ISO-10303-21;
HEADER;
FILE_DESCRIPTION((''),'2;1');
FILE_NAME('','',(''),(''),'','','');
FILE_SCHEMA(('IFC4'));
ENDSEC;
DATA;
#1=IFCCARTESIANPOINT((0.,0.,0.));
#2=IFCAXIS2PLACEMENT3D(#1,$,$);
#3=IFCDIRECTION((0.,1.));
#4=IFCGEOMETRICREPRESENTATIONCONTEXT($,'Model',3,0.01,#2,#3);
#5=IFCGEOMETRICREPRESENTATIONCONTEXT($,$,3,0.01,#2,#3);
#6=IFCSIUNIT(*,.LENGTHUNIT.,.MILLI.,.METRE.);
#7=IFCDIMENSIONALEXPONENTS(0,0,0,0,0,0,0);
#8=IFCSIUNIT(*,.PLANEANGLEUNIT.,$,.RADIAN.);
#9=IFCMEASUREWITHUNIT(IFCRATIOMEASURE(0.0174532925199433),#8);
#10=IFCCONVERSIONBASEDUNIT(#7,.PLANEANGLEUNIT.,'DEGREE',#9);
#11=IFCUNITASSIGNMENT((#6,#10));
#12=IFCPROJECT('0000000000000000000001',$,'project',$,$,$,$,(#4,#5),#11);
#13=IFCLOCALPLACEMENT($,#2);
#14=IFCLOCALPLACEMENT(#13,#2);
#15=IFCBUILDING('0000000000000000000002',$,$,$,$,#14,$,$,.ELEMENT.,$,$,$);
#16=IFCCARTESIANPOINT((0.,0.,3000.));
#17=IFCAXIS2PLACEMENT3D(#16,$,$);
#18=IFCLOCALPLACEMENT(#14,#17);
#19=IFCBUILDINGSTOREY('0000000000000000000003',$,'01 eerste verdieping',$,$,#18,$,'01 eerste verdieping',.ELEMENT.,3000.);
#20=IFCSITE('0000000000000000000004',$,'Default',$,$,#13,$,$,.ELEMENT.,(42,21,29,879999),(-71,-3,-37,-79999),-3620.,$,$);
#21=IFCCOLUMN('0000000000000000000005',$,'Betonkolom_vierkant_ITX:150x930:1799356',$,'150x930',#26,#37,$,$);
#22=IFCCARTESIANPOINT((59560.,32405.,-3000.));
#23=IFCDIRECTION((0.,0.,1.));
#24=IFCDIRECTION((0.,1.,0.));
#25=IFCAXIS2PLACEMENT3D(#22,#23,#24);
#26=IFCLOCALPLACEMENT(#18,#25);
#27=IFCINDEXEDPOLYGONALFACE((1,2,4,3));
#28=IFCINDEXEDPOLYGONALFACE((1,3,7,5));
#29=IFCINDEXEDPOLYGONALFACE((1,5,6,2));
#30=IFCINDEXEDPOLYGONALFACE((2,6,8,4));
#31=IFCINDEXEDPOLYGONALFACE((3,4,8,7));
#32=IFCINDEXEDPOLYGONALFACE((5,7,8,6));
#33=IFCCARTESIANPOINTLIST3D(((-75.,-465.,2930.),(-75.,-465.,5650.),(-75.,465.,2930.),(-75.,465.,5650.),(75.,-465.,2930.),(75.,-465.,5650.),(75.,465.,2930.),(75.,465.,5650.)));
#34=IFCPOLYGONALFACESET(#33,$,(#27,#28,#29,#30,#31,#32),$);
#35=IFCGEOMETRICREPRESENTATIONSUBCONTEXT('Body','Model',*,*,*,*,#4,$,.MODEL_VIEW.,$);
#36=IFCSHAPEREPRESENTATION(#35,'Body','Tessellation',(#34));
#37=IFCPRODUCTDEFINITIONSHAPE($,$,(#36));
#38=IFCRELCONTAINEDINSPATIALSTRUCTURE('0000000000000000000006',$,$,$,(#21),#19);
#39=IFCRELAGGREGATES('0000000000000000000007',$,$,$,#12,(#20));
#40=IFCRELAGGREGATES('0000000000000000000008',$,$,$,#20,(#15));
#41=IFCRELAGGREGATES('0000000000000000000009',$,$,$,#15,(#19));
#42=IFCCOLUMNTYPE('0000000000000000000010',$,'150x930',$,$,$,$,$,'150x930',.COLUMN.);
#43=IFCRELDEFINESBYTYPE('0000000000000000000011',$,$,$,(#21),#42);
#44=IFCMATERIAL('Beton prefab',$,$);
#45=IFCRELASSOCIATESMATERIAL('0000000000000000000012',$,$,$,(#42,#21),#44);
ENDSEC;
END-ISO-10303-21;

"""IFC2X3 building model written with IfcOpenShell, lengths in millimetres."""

from ifc_helpers import new_model, entity, si_unit, converted_unit, direction, frame, origin, origin_2d_with_axis, place, context, subcontext, project, spatial, rectangle, extrude, source, transform, mapped, material, type_object, type_shapes, element, save


model = new_model("IFC2X3")

# Units and contexts
model_context = context("Model", 3, precision=0.01, world=origin(), true_north=direction((0.0, 1.0)))
context_of_model = context(None, 3, precision=0.01, world=origin(), true_north=direction((0.0, 1.0)))
body_context = subcontext(model_context, "Body", "Model", "MODEL_VIEW")
ifc_project = project(units=[si_unit("LENGTHUNIT", "METRE", prefix="MILLI"), converted_unit("PLANEANGLEUNIT", "DEGREE", entity("IfcRatioMeasure", 0.0174532925199433), si_unit("PLANEANGLEUNIT", "RADIAN"), dimensions=[0, 0, 0, 0, 0, 0, 0])], contexts=[model_context, context_of_model])

# Site, building, storey
site_placement = place(None, origin())
site = spatial("IfcSite", under=ifc_project, at=site_placement, Name="Default", CompositionType="ELEMENT", RefLatitude=(42, 21, 29, 879999), RefLongitude=(-71, -3, -37, -79999), RefElevation=-3620.0)
building_placement = place(site_placement, origin())
building = spatial("IfcBuilding", under=site, at=building_placement, CompositionType="ELEMENT")
storey_placement = place(building_placement, frame((0.0, 0.0, 3000.0)))
storey = spatial("IfcBuildingStorey", under=building, at=storey_placement, Name="01 eerste verdieping", LongName="01 eerste verdieping", CompositionType="ELEMENT", Elevation=3000.0)

# Column
ifc_material_1 = material(Name="Beton prefab")
column_type = type_object("IfcColumnType", Name="150x930", ElementType="150x930", PredefinedType="COLUMN", material=ifc_material_1)
shared_shape = source(origin(), body_context, "Body", "SweptSolid", [
    extrude(rectangle(XDim=930.0, YDim=150.0, at=origin_2d_with_axis()), frame((0.0, 0.0, 2930.0), z_axis=(0.0, 0.0, 1.0), x_axis=(0.0, -1.0, 0.0)), (0.0, 0.0, 1.0), 2720.0),
])
type_shapes(column_type, [shared_shape])
column_placement = place(storey_placement, frame((59560.0, 32405.0, -3000.0), z_axis=(0.0, 0.0, 1.0), x_axis=(0.0, 1.0, 0.0)))
element("IfcColumn", 1, at=column_placement, inside=storey, type_object=column_type, material=ifc_material_1, Name="Betonkolom_vierkant_ITX:150x930:1799356", ObjectType="150x930", context=body_context, shape_type="MappedRepresentation", body=[
    mapped(shared_shape, transform((0.0, 0.0, 0.0), scale=1.0)),
])

save(model, "model.ifc")
